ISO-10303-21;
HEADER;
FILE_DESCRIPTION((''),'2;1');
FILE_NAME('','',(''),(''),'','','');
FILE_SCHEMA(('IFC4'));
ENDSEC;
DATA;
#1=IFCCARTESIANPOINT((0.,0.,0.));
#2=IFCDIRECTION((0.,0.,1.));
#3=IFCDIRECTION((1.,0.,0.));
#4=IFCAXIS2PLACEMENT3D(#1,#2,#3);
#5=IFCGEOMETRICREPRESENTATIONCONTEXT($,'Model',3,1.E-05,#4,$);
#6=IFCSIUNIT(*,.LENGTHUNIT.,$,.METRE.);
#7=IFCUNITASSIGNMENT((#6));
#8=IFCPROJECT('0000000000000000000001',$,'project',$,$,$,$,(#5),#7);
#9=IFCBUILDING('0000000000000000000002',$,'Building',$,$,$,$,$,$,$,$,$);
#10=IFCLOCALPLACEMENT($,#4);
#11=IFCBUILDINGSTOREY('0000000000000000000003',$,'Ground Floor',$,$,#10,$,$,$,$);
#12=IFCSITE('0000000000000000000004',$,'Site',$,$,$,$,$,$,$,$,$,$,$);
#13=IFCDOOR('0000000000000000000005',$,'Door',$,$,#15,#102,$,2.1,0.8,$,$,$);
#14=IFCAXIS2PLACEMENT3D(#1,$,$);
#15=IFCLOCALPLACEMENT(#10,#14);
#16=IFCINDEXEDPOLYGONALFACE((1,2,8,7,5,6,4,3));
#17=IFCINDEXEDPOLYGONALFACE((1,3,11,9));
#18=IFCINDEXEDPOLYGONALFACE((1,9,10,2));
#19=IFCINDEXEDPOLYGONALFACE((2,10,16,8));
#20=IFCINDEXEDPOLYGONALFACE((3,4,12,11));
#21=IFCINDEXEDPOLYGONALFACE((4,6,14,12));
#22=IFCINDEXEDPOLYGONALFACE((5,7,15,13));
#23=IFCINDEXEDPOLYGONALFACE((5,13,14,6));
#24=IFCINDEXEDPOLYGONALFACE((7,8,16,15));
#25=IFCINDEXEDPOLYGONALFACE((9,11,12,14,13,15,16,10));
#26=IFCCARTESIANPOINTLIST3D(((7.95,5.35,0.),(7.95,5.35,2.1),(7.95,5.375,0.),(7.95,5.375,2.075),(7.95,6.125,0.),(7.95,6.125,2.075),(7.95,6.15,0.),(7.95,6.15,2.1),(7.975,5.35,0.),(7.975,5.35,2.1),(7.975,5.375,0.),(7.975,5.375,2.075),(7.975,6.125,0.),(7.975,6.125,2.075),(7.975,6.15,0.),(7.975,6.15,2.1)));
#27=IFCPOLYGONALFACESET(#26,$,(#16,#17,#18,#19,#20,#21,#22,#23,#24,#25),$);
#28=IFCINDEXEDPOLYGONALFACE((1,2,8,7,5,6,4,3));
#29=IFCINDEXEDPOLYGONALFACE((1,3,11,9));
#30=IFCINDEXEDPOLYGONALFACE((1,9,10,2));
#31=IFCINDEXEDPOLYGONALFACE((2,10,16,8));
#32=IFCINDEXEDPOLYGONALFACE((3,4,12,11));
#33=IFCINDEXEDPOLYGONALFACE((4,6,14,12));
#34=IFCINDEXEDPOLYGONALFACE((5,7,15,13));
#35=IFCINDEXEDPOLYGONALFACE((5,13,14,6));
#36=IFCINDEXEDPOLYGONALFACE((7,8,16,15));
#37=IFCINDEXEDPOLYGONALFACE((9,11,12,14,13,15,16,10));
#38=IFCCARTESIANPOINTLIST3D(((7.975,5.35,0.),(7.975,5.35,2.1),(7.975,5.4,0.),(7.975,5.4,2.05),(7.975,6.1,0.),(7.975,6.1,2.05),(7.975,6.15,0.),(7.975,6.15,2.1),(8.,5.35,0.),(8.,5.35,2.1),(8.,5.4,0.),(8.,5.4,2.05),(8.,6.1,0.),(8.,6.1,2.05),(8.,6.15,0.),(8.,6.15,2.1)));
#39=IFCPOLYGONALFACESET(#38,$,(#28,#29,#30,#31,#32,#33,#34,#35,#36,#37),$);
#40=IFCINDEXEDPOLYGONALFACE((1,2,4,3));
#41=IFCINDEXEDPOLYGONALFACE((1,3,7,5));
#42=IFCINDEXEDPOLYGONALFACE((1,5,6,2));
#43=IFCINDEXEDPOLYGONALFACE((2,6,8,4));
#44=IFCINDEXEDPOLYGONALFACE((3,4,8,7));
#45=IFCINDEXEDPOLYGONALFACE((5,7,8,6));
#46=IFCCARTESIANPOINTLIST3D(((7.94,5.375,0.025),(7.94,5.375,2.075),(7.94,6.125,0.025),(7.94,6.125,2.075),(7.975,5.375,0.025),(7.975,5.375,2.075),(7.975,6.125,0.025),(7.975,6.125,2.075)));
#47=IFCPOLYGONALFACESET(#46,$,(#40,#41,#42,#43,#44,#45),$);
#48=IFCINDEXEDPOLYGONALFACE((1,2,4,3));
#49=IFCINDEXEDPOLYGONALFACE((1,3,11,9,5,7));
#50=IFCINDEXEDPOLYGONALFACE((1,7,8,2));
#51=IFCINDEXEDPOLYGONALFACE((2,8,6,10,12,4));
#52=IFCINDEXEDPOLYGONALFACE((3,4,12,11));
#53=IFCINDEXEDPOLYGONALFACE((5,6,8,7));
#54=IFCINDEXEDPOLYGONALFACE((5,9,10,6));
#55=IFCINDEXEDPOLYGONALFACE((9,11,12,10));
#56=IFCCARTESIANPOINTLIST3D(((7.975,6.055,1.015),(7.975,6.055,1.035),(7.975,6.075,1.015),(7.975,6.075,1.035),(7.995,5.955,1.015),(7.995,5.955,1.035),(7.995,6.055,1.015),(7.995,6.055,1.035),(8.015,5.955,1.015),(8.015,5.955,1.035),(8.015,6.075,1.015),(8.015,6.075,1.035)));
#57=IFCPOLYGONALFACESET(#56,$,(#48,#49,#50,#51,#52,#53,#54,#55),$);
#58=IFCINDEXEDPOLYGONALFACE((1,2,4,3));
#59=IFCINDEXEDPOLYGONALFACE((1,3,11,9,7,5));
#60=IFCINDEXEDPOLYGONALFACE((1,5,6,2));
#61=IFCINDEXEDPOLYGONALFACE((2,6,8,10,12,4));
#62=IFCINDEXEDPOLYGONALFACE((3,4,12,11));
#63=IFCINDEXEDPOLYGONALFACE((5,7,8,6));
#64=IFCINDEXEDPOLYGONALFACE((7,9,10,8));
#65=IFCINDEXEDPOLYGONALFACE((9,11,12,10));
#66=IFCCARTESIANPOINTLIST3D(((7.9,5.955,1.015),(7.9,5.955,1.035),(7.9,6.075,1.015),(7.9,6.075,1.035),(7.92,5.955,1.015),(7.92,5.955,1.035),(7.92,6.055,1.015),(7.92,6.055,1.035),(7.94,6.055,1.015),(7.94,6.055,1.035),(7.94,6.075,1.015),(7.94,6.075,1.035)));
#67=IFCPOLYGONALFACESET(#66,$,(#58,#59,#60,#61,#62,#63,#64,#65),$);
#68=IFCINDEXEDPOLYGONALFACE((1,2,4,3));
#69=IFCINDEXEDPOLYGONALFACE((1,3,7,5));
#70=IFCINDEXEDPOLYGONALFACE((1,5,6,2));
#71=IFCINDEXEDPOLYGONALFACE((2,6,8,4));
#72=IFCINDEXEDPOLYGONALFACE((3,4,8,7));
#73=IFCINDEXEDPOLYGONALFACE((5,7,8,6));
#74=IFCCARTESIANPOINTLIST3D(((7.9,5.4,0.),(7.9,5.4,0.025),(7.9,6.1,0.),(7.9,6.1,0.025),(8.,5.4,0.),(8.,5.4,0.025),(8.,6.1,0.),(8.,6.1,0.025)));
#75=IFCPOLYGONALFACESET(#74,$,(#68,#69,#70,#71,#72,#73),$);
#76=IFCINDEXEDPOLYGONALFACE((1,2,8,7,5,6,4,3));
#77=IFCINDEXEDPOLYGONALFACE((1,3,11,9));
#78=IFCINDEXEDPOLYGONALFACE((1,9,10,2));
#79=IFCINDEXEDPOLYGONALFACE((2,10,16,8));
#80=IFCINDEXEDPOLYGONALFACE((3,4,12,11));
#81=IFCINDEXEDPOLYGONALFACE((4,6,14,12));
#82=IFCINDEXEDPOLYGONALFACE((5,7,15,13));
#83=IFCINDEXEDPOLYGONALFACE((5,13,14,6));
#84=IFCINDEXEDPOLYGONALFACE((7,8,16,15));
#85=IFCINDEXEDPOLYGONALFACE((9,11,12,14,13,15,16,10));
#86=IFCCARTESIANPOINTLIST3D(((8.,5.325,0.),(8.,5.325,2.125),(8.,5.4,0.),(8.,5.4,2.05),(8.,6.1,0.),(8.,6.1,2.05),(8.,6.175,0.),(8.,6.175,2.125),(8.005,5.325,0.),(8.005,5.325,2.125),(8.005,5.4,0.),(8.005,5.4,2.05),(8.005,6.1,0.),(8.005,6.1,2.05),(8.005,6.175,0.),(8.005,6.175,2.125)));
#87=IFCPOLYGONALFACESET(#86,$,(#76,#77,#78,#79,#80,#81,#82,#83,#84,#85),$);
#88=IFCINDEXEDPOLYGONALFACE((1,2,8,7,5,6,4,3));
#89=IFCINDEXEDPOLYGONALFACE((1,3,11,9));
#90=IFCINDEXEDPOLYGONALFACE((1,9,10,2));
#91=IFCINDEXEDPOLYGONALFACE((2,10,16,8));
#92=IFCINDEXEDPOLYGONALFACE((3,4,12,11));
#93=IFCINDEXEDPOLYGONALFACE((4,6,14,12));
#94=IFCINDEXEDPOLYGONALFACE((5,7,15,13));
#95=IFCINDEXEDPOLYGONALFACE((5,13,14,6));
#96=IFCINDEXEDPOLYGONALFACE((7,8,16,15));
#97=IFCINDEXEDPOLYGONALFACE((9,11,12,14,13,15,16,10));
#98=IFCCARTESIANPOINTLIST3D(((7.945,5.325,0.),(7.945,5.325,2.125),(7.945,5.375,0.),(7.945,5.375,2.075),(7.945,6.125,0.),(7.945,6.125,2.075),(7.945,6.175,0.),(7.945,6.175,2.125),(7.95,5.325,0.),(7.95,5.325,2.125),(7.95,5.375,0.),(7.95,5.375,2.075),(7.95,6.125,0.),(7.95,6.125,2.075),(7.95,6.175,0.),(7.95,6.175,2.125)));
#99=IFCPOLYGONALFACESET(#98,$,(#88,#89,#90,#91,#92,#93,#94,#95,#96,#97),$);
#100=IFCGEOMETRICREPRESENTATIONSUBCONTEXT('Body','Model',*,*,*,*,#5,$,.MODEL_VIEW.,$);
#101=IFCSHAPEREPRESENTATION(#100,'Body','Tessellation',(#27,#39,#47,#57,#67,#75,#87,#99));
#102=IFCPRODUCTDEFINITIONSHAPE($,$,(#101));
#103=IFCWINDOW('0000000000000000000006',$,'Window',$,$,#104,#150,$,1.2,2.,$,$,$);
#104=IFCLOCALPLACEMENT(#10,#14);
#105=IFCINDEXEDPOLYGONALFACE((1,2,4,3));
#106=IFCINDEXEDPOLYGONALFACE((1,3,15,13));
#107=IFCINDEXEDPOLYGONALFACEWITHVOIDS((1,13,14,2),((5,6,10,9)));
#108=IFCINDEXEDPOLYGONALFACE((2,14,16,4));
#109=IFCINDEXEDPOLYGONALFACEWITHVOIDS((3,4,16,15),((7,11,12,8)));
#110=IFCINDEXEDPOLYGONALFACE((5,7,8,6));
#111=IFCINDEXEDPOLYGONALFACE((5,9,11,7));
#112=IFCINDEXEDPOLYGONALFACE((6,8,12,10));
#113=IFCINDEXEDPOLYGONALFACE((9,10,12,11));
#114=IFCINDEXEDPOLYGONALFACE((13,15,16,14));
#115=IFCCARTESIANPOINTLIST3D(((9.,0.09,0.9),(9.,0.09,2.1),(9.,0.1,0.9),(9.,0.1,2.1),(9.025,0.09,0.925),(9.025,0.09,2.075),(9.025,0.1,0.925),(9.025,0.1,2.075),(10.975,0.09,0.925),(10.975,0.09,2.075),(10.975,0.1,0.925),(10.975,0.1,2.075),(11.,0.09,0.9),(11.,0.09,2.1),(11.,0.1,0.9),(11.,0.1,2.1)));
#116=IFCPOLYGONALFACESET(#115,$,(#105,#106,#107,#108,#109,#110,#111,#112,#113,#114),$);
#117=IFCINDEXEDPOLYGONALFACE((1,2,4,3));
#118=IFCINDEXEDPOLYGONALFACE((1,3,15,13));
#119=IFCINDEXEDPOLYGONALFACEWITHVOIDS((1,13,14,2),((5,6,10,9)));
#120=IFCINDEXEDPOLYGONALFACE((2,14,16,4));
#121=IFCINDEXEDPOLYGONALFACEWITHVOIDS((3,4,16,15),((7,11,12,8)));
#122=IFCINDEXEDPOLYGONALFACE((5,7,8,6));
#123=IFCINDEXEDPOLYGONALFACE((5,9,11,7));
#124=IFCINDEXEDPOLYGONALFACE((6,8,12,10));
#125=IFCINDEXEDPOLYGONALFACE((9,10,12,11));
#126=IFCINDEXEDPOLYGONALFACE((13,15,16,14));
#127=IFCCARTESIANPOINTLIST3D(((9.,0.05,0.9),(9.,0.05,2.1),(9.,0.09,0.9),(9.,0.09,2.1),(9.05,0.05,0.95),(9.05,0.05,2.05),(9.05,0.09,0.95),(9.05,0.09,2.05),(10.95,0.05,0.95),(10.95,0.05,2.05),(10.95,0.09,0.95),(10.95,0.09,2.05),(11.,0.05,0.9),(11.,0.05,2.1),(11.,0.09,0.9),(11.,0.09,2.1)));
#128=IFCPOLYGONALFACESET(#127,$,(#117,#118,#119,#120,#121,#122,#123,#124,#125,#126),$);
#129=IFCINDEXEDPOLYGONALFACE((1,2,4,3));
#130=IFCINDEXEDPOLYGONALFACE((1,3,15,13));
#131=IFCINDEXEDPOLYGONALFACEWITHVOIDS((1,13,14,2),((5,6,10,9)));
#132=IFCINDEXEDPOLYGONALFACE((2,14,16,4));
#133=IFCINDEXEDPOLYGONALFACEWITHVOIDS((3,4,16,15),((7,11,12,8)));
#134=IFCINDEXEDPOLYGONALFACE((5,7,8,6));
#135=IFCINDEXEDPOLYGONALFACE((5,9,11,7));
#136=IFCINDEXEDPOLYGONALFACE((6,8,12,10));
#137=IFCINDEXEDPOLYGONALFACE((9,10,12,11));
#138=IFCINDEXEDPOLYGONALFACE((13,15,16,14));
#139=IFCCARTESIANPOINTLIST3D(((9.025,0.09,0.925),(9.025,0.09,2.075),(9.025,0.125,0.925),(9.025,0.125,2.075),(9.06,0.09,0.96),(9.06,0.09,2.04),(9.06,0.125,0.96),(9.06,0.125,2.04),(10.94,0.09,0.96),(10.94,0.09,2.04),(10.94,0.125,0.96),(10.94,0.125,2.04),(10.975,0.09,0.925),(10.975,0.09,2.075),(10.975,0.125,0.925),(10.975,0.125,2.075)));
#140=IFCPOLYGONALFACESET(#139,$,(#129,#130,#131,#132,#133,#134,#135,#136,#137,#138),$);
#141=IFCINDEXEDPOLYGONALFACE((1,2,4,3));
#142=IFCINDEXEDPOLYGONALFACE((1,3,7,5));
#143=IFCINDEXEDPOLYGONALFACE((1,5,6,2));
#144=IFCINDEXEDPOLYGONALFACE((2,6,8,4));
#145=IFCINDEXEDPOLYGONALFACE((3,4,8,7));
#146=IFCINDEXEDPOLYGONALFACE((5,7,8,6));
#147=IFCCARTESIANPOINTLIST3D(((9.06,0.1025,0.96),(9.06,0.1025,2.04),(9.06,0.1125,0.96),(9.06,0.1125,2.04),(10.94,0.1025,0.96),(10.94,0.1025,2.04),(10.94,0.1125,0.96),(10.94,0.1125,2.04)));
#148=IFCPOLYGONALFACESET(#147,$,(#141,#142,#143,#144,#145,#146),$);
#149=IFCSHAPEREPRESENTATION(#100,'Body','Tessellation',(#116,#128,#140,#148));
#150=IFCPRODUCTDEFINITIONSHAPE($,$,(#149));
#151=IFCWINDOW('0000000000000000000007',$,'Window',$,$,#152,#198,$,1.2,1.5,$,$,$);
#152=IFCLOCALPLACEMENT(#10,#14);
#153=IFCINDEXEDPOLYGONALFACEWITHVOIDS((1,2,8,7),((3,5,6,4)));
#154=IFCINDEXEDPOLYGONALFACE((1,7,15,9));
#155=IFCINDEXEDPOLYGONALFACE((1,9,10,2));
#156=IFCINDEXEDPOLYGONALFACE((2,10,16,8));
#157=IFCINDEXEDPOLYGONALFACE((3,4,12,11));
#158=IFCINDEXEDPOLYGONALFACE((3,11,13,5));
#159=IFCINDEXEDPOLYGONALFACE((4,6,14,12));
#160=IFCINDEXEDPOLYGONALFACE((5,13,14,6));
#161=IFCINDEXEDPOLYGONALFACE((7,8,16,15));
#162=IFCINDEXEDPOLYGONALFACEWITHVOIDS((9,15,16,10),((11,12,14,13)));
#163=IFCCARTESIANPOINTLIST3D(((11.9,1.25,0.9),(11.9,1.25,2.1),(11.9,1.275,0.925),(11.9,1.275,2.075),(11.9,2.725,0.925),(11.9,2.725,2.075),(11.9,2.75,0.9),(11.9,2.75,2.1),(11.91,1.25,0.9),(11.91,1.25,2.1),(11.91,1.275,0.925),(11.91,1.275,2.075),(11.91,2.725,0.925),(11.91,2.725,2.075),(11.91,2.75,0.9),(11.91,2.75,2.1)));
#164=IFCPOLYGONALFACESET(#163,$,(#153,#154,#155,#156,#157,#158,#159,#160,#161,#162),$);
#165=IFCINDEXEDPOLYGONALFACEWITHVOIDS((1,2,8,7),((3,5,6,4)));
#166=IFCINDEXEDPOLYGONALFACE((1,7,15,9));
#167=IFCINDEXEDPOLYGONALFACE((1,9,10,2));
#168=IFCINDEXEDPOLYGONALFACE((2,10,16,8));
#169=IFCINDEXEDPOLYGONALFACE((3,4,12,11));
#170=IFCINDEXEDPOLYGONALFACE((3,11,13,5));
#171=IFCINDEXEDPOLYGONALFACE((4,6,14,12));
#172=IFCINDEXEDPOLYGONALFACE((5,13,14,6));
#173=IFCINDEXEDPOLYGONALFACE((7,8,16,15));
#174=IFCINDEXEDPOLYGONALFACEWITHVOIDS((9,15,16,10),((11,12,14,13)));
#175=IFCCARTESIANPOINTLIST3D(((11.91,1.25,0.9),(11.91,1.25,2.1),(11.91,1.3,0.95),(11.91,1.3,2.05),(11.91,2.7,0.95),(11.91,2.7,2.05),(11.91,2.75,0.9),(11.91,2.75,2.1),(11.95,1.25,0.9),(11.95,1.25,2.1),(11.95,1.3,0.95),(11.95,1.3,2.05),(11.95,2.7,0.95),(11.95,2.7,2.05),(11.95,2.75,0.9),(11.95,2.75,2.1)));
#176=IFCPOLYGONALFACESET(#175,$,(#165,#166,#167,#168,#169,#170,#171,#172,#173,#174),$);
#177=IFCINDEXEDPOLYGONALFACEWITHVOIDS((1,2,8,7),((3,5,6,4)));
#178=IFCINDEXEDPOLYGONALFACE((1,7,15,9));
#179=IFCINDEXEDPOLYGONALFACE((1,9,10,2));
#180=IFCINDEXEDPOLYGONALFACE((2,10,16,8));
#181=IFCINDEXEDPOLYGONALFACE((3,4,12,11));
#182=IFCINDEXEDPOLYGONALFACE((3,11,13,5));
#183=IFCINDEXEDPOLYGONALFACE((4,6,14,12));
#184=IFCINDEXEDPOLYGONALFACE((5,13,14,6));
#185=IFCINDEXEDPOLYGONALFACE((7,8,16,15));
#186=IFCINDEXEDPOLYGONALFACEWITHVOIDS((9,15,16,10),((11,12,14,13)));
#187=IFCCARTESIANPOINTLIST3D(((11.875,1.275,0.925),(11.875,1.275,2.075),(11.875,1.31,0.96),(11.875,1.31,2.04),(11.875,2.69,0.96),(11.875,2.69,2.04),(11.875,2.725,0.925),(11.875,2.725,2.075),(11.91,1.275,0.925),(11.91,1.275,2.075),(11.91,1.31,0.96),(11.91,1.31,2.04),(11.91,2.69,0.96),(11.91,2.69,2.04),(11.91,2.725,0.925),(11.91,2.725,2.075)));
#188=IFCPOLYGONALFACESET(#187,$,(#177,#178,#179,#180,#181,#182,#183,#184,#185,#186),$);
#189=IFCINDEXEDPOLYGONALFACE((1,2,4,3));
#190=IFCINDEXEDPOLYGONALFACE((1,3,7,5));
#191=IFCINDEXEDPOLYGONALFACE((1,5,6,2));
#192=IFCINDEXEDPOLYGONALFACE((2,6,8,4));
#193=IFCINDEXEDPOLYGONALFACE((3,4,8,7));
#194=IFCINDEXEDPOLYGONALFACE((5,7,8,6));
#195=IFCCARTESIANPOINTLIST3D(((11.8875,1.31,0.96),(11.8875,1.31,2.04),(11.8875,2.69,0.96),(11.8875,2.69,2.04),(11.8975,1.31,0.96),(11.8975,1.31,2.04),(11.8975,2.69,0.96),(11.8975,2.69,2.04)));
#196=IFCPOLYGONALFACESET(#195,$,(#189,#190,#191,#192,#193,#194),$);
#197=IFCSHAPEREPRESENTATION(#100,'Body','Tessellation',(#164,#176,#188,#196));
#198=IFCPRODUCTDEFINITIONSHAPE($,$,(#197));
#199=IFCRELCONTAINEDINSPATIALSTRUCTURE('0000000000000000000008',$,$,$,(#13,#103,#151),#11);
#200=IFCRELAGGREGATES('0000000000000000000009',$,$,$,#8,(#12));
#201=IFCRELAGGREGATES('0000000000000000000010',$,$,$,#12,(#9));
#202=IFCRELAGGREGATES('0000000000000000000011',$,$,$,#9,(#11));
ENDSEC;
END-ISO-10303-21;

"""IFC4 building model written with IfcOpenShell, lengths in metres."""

from ifc_helpers import new_model, si_unit, frame, origin_with_axes, place, context, subcontext, project, spatial, line, indexed_curve, outline, extrude, element, save


model = new_model("IFC4")

# Units and contexts
model_context = context("Model", 3, precision=1e-05, world=origin_with_axes())
body_context = subcontext(model_context, "Body", "Model", "MODEL_VIEW")
ifc_project = project(units=[si_unit("LENGTHUNIT", "METRE")], contexts=[model_context])

# Site, building, storey
site = spatial("IfcSite", under=ifc_project, Name="Site")
building = spatial("IfcBuilding", under=site, Name="Building")
storey_placement = place(None, origin_with_axes())
storey = spatial("IfcBuildingStorey", under=building, at=storey_placement, Name="Ground Floor")

# Door
door_1_placement = place(storey_placement, frame((8.0, 5.35, 0.0), z_axis=(0.0, 0.0, 1.0), x_axis=(0.0, 1.0, 0.0)))
element("IfcDoor", 1, at=door_1_placement, inside=storey, Name="Door", OverallHeight=2.1, OverallWidth=0.8, context=body_context, shape_type="SweptSolid", body=[
    extrude(outline(indexed_curve([(0.0, 0.0), (0.0, 2.1), (0.8, 2.1), (0.8, 0.0), (0.775, 0.0), (0.775, 2.075), (0.025, 2.075), (0.025, 0.0)], segments=[line(1, 2, 3, 4, 5, 6, 7, 8, 1)])), frame((0.0, 0.025, 0.0), z_axis=(0.0, -1.0, 0.0), x_axis=(1.0, 0.0, 0.0)), (0.0, 0.0, -1.0), 0.025),
    extrude(outline(indexed_curve([(0.0, 0.0), (0.0, 2.1), (0.8, 2.1), (0.8, 0.0), (0.75, 0.0), (0.75, 2.05), (0.05, 2.05), (0.05, 0.0)], segments=[line(1, 2, 3, 4, 5, 6, 7, 8, 1)])), frame((0.0, 0.0, 0.0), z_axis=(0.0, -1.0, 0.0), x_axis=(1.0, 0.0, 0.0)), (0.0, 0.0, -1.0), 0.025),
    extrude(outline(indexed_curve([(0.0, 0.0), (0.75, 0.0), (0.75, 0.035), (0.0, 0.035)], segments=[line(1, 2, 3, 4, 1)])), frame((0.025, 0.025, 0.025), z_axis=(0.0, 0.0, 1.0), x_axis=(1.0, 0.0, 0.0)), (0.0, 0.0, 1.0), 2.05),
    extrude(outline(indexed_curve([(0.0, 0.0), (0.0, -0.04), (-0.12, -0.04), (-0.12, -0.02), (-0.02, -0.02), (-0.02, 0.0)], segments=[line(1, 2, 3, 4, 5, 6, 1)])), frame((0.725, 0.025, 1.015), z_axis=(0.0, 0.0, 1.0), x_axis=(1.0, 0.0, 0.0)), (0.0, 0.0, 1.0), 0.02),
    extrude(outline(indexed_curve([(0.0, 0.0), (0.0, 0.04), (-0.12, 0.04), (-0.12, 0.02), (-0.02, 0.02), (-0.02, 0.0)], segments=[line(1, 2, 3, 4, 5, 6, 1)])), frame((0.725, 0.06, 1.015), z_axis=(0.0, 0.0, 1.0), x_axis=(1.0, 0.0, 0.0)), (0.0, 0.0, 1.0), 0.02),
    extrude(outline(indexed_curve([(0.0, 0.0), (0.7, 0.0), (0.7, 0.1), (0.0, 0.1)], segments=[line(1, 2, 3, 4, 1)])), frame((0.05, 0.0, 0.0), z_axis=(0.0, 0.0, 1.0), x_axis=(1.0, 0.0, 0.0)), (0.0, 0.0, 1.0), 0.025),
    extrude(outline(indexed_curve([(0.0, 0.0), (0.0, 2.125), (0.85, 2.125), (0.85, 0.0), (0.775, 0.0), (0.775, 2.05), (0.075, 2.05), (0.075, 0.0)], segments=[line(1, 2, 3, 4, 5, 6, 7, 8, 1)])), frame((-0.025, -0.005, 0.0), z_axis=(0.0, -1.0, 0.0), x_axis=(1.0, 0.0, 0.0)), (0.0, 0.0, -1.0), 0.005),
    extrude(outline(indexed_curve([(0.0, 0.0), (0.0, 2.125), (0.85, 2.125), (0.85, 0.0), (0.8, 0.0), (0.8, 2.075), (0.05, 2.075), (0.05, 0.0)], segments=[line(1, 2, 3, 4, 5, 6, 7, 8, 1)])), frame((-0.025, 0.05, 0.0), z_axis=(0.0, -1.0, 0.0), x_axis=(1.0, 0.0, 0.0)), (0.0, 0.0, -1.0), 0.005),
])

# Windows
window_1_placement = place(storey_placement, frame((9.0, 0.0, 0.9), z_axis=(0.0, 0.0, 1.0), x_axis=(1.0, 0.0, 0.0)))
element("IfcWindow", 2, at=window_1_placement, inside=storey, Name="Window", OverallHeight=1.2, OverallWidth=2.0, context=body_context, shape_type="SweptSolid", body=[
    extrude(outline(indexed_curve([(0.0, 0.0), (2.0, 0.0), (2.0, 1.2), (0.0, 1.2)], segments=[line(1, 2, 3, 4, 1)]), holes=[indexed_curve([(0.025, 0.025), (1.975, 0.025), (1.975, 1.175), (0.025, 1.175)], segments=[line(1, 2, 3, 4, 1)])]), frame((0.0, 0.09, 0.0), z_axis=(0.0, -1.0, 0.0), x_axis=(1.0, 0.0, 0.0)), (0.0, 0.0, -1.0), 0.01),
    extrude(outline(indexed_curve([(0.0, 0.0), (2.0, 0.0), (2.0, 1.2), (0.0, 1.2)], segments=[line(1, 2, 3, 4, 1)]), holes=[indexed_curve([(0.05, 0.05), (1.95, 0.05), (1.95, 1.15), (0.05, 1.15)], segments=[line(1, 2, 3, 4, 1)])]), frame((0.0, 0.05, 0.0), z_axis=(0.0, -1.0, 0.0), x_axis=(1.0, 0.0, 0.0)), (0.0, 0.0, -1.0), 0.04),
    extrude(outline(indexed_curve([(0.0, 0.0), (1.95, 0.0), (1.95, 1.15), (0.0, 1.15)], segments=[line(1, 2, 3, 4, 1)]), holes=[indexed_curve([(0.035, 0.035), (1.915, 0.035), (1.915, 1.115), (0.035, 1.115)], segments=[line(1, 2, 3, 4, 1)])]), frame((0.025, 0.09, 0.025), z_axis=(0.0, -1.0, 0.0), x_axis=(1.0, 0.0, 0.0)), (0.0, 0.0, -1.0), 0.035),
    extrude(outline(indexed_curve([(0.035, 0.035), (1.915, 0.035), (1.915, 1.115), (0.035, 1.115)], segments=[line(1, 2, 3, 4, 1)])), frame((0.025, 0.1025, 0.025), z_axis=(0.0, -1.0, 0.0), x_axis=(1.0, 0.0, 0.0)), (0.0, 0.0, -1.0), 0.01),
])
window_2_placement = place(storey_placement, frame((12.0, 1.25, 0.9), z_axis=(0.0, 0.0, 1.0), x_axis=(0.0, 1.0, 0.0)))
element("IfcWindow", 3, at=window_2_placement, inside=storey, Name="Window", OverallHeight=1.2, OverallWidth=1.5, context=body_context, shape_type="SweptSolid", body=[
    extrude(outline(indexed_curve([(0.0, 0.0), (1.5, 0.0), (1.5, 1.2), (0.0, 1.2)], segments=[line(1, 2, 3, 4, 1)]), holes=[indexed_curve([(0.025, 0.025), (1.475, 0.025), (1.475, 1.175), (0.025, 1.175)], segments=[line(1, 2, 3, 4, 1)])]), frame((0.0, 0.09, 0.0), z_axis=(0.0, -1.0, 0.0), x_axis=(1.0, 0.0, 0.0)), (0.0, 0.0, -1.0), 0.01),
    extrude(outline(indexed_curve([(0.0, 0.0), (1.5, 0.0), (1.5, 1.2), (0.0, 1.2)], segments=[line(1, 2, 3, 4, 1)]), holes=[indexed_curve([(0.05, 0.05), (1.45, 0.05), (1.45, 1.15), (0.05, 1.15)], segments=[line(1, 2, 3, 4, 1)])]), frame((0.0, 0.05, 0.0), z_axis=(0.0, -1.0, 0.0), x_axis=(1.0, 0.0, 0.0)), (0.0, 0.0, -1.0), 0.04),
    extrude(outline(indexed_curve([(0.0, 0.0), (1.45, 0.0), (1.45, 1.15), (0.0, 1.15)], segments=[line(1, 2, 3, 4, 1)]), holes=[indexed_curve([(0.035, 0.035), (1.415, 0.035), (1.415, 1.115), (0.035, 1.115)], segments=[line(1, 2, 3, 4, 1)])]), frame((0.025, 0.09, 0.025), z_axis=(0.0, -1.0, 0.0), x_axis=(1.0, 0.0, 0.0)), (0.0, 0.0, -1.0), 0.035),
    extrude(outline(indexed_curve([(0.035, 0.035), (1.415, 0.035), (1.415, 1.115), (0.035, 1.115)], segments=[line(1, 2, 3, 4, 1)])), frame((0.025, 0.1025, 0.025), z_axis=(0.0, -1.0, 0.0), x_axis=(1.0, 0.0, 0.0)), (0.0, 0.0, -1.0), 0.01),
])

save(model, "model.ifc")
